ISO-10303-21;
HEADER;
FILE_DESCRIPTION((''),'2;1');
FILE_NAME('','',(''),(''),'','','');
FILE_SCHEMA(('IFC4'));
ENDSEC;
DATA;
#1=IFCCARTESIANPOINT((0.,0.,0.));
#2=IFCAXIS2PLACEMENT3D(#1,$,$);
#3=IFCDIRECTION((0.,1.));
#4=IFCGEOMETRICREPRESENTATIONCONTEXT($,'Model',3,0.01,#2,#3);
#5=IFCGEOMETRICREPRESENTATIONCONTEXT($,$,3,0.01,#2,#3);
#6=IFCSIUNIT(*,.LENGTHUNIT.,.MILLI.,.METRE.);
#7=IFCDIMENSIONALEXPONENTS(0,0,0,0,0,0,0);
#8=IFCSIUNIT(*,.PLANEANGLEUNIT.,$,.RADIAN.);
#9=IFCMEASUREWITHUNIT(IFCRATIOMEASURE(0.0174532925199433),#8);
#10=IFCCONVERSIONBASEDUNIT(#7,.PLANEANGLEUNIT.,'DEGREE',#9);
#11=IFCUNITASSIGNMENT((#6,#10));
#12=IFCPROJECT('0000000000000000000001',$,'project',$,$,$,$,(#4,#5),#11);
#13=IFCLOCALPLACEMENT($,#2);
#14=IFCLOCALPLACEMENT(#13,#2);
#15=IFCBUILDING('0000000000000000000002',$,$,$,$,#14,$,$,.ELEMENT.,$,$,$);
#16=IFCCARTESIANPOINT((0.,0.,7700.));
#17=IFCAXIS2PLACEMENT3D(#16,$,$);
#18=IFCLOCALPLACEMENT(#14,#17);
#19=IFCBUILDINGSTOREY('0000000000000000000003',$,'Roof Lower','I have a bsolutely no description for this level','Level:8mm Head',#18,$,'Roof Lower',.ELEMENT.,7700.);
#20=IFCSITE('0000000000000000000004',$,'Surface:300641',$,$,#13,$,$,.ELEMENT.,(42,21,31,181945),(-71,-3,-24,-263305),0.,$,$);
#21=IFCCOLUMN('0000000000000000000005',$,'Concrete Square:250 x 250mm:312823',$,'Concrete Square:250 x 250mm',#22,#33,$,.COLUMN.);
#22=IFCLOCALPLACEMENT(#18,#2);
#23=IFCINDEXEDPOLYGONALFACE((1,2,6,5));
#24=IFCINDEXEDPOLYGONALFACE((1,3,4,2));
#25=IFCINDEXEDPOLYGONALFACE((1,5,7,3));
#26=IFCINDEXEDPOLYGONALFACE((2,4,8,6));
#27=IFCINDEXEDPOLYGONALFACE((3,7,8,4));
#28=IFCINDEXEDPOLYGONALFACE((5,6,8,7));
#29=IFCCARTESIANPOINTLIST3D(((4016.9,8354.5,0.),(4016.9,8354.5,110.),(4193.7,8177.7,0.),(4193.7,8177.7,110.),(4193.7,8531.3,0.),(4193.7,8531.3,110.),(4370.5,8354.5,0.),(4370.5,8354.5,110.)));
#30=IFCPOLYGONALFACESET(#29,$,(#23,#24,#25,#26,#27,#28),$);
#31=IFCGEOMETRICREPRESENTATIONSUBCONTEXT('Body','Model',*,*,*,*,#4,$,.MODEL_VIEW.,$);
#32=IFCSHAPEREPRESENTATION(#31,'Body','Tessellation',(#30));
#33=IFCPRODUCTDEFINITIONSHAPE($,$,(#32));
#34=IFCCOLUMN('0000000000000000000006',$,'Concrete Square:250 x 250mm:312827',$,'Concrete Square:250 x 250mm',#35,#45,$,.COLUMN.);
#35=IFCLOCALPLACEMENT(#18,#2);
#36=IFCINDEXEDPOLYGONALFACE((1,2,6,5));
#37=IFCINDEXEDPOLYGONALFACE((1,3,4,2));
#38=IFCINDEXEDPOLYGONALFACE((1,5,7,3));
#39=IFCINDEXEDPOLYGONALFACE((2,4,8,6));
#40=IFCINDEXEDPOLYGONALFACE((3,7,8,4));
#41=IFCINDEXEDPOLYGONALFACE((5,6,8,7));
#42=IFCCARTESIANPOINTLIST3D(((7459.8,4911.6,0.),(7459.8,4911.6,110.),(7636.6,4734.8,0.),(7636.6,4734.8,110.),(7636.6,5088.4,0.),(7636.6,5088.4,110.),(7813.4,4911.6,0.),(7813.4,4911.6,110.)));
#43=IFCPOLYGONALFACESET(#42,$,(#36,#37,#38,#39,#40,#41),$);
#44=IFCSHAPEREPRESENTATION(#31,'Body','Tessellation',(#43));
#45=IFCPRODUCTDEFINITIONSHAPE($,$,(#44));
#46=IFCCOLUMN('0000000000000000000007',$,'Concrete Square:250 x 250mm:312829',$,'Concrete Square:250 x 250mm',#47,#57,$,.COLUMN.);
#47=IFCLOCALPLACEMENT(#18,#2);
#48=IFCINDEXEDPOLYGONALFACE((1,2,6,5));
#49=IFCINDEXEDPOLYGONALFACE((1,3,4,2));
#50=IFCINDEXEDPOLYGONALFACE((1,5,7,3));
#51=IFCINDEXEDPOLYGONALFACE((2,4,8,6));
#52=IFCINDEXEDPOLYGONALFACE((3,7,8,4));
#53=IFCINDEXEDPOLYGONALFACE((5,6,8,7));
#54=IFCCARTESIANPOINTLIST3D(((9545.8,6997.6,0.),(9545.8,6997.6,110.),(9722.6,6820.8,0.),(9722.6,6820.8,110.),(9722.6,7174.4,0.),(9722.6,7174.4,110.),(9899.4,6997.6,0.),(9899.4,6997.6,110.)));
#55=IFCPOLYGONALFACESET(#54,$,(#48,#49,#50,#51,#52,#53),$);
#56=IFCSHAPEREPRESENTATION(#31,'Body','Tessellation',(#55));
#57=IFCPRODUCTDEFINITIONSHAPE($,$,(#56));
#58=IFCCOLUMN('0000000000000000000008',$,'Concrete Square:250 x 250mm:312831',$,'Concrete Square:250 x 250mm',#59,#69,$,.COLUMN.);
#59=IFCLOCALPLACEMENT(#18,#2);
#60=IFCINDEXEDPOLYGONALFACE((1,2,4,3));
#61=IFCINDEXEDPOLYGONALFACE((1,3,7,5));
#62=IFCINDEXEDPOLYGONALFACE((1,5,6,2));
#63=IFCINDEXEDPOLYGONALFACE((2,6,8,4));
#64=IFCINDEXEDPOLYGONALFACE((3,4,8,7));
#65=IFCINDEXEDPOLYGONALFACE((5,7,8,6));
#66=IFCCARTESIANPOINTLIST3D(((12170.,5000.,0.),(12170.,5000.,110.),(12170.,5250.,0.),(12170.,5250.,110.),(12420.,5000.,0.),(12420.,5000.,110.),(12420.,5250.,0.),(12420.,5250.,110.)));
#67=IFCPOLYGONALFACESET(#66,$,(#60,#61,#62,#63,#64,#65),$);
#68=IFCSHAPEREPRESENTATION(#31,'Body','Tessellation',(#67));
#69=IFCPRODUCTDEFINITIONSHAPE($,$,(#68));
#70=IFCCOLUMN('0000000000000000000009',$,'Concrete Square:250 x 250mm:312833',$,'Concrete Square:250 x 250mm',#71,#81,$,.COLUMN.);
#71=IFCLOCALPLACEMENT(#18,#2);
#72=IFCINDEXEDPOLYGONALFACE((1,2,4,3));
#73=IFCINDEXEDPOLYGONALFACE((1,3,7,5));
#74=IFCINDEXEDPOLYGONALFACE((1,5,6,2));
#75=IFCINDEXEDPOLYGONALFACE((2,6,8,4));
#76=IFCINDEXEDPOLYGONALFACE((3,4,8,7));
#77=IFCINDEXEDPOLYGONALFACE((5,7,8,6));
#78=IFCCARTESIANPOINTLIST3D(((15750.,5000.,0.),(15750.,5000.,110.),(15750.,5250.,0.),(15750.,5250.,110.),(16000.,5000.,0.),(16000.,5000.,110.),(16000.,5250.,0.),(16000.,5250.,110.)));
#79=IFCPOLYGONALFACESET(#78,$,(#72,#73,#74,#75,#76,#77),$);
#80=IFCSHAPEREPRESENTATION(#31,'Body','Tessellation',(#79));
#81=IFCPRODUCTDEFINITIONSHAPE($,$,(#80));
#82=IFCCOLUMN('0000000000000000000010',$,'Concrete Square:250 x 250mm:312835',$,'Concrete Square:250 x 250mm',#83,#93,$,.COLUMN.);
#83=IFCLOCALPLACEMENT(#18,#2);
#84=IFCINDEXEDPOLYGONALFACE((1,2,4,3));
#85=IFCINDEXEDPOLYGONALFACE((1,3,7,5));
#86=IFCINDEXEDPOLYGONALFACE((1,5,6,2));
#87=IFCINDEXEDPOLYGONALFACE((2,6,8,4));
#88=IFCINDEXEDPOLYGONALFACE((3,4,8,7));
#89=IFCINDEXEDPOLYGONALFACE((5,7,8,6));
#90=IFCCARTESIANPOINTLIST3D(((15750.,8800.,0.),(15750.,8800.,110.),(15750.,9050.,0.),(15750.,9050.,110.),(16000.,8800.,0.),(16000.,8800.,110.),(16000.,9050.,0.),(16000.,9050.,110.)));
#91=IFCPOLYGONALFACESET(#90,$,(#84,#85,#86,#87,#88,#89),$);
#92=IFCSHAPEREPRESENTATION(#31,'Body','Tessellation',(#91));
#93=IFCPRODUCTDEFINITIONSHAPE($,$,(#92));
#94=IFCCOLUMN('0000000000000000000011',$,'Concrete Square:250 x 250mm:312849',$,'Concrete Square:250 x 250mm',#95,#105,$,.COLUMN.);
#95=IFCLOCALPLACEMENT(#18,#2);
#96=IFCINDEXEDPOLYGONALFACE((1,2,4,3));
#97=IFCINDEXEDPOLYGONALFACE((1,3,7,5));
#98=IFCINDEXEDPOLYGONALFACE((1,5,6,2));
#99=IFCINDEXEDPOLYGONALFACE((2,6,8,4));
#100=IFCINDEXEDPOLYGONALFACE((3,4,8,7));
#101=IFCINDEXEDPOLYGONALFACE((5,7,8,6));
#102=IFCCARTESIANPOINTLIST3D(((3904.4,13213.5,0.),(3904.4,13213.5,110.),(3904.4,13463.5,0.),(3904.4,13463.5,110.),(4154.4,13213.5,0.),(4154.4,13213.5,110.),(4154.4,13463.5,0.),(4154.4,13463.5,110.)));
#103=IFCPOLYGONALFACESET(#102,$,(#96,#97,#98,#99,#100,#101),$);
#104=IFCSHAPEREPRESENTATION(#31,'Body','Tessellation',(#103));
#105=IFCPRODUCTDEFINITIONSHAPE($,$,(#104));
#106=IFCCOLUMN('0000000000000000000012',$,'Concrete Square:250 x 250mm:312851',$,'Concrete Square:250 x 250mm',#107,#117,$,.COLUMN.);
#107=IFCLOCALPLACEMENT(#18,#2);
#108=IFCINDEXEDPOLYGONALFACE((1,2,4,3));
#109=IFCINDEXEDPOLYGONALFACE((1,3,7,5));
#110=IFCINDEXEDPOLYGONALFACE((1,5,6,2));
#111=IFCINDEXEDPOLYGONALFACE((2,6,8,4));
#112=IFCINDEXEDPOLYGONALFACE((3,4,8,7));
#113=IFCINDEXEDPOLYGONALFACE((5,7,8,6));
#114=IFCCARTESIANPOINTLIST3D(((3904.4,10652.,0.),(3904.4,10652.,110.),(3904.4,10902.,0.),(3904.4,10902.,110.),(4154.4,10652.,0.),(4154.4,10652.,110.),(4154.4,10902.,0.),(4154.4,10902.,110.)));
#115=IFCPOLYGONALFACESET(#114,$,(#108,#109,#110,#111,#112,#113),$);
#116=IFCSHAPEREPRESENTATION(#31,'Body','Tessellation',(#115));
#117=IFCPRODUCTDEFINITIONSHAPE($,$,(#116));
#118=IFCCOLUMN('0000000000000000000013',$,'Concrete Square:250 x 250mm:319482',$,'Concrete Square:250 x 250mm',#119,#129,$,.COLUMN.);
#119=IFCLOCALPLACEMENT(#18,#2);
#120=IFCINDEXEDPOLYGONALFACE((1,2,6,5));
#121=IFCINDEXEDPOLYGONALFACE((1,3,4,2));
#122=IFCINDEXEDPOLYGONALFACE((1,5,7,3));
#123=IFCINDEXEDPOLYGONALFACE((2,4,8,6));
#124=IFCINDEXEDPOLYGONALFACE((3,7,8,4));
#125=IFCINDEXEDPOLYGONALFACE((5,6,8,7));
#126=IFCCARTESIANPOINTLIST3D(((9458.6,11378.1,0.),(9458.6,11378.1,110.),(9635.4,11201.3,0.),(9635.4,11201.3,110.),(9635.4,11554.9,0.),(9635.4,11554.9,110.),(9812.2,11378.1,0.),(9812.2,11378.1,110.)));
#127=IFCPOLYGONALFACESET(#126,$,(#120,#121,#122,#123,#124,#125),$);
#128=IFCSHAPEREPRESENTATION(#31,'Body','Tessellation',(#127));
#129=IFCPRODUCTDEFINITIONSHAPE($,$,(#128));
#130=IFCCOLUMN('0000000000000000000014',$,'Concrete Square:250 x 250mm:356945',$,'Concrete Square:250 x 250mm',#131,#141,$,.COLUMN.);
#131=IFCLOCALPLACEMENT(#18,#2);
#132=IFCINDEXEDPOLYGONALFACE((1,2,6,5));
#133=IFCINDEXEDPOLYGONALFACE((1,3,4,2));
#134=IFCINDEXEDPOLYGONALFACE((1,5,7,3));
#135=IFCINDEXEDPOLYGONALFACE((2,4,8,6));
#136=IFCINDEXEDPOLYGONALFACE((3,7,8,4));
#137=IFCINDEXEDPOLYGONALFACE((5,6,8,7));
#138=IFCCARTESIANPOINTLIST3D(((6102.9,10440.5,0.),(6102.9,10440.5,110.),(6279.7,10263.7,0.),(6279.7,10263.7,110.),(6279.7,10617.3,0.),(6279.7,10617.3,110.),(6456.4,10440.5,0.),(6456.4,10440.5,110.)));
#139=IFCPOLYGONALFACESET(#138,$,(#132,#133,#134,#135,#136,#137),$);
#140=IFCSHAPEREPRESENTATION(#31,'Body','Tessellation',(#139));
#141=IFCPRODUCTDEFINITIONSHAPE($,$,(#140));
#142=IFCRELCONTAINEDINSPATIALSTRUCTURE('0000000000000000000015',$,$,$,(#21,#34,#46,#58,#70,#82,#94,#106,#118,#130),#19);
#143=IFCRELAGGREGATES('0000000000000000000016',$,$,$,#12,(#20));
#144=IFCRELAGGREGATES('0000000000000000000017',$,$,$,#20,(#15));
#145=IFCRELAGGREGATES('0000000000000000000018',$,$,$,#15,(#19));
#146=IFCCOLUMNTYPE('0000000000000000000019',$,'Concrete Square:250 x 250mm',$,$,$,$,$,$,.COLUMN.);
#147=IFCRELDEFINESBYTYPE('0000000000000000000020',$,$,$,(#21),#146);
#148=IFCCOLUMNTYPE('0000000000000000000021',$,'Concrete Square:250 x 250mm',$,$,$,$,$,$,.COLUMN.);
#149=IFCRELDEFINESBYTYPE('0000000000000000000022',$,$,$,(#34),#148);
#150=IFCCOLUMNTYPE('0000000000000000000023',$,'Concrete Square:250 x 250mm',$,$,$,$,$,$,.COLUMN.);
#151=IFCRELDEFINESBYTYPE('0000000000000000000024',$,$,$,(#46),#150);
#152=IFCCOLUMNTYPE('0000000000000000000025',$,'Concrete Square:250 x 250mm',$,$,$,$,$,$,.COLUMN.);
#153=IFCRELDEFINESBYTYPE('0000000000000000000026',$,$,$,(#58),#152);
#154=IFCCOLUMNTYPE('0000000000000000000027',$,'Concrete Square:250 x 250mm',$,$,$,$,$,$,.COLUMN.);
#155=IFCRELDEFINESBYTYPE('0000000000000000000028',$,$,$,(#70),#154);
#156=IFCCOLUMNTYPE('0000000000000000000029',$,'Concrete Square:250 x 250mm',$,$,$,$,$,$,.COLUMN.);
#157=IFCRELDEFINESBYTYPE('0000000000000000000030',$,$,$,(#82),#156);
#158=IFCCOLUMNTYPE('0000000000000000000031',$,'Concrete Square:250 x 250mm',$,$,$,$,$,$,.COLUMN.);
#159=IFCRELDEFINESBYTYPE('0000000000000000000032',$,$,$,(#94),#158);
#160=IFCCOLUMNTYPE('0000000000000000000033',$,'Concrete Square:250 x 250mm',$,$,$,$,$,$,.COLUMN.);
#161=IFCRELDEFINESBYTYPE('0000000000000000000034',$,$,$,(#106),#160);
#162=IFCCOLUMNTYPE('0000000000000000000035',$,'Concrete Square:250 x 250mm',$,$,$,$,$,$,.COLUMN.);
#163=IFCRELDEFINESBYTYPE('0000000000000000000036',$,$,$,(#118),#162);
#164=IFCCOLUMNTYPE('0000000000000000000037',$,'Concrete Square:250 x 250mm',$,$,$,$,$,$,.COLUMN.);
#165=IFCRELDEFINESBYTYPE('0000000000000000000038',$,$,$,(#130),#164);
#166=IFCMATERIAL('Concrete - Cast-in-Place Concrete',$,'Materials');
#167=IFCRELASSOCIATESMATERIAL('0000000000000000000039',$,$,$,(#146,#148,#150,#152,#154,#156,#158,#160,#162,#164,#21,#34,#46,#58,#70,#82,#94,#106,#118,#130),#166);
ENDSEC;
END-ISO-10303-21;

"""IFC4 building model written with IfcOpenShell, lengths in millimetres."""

from ifc_helpers import new_model, entity, si_unit, converted_unit, direction, frame, frame_2d, origin, origin_2d_with_axis, place, context, subcontext, project, spatial, rectangle, extrude, source, transform, mapped, material, material_profile, profile_set, profile_usage, type_object, type_shapes, element, save


model = new_model("IFC4")

# Units and contexts
model_context = context("Model", 3, precision=0.01, world=origin(), true_north=direction((0.0, 1.0)))
context_of_model = context(None, 3, precision=0.01, world=origin(), true_north=direction((0.0, 1.0)))
body_context = subcontext(model_context, "Body", "Model", "MODEL_VIEW")
ifc_project = project(units=[si_unit("LENGTHUNIT", "METRE", prefix="MILLI"), converted_unit("PLANEANGLEUNIT", "DEGREE", entity("IfcRatioMeasure", 0.0174532925199433), si_unit("PLANEANGLEUNIT", "RADIAN"), dimensions=[0, 0, 0, 0, 0, 0, 0])], contexts=[model_context, context_of_model])

# Site, building, storey
site_placement = place(None, origin())
site = spatial("IfcSite", under=ifc_project, at=site_placement, Name="Surface:300641", CompositionType="ELEMENT", RefLatitude=(42, 21, 31, 181945), RefLongitude=(-71, -3, -24, -263305), RefElevation=0.0)
building_placement = place(site_placement, origin())
building = spatial("IfcBuilding", under=site, at=building_placement, CompositionType="ELEMENT")
storey_placement = place(building_placement, frame((0.0, 0.0, 7700.0)))
storey = spatial("IfcBuildingStorey", under=building, at=storey_placement, Name="Roof Lower", Description="I have a bsolutely no description for this level", ObjectType="Level:8mm Head", LongName="Roof Lower", CompositionType="ELEMENT", Elevation=7700.0)

# Columns
ifc_material_1 = material(Name="Concrete - Cast-in-Place Concrete", Category="Materials")
ifc_material_profile_1 = material_profile(ifc_material_1, rectangle(XDim=250.0, YDim=250.0, at=frame_2d((0.0, 0.0), x_axis=(1.0, 0.0))), Name="250 x 250mm")
ifc_profile_set_1 = profile_set([ifc_material_profile_1], Name="250 x 250mm")
ifc_profile_usage_1 = profile_usage(ifc_profile_set_1)
column_type_1 = type_object("IfcColumnType", Name="Concrete Square:250 x 250mm", PredefinedType="COLUMN", material=ifc_profile_set_1)
shared_shape_1 = source(origin(), body_context, "Body", "SweptSolid", [
    extrude(rectangle(XDim=250.0, YDim=250.0, at=frame_2d((0.0, 0.0), x_axis=(1.0, 0.0))), frame((4193.7, 8354.5, 7700.0), z_axis=(0.0, 0.0, 1.0), x_axis=(-0.707107, 0.707107, 0.0)), (0.0, 0.0, 1.0), 110.0),
])
type_shapes(column_type_1, [shared_shape_1])
column_1_placement = place(storey_placement, frame((0.0, 0.0, -7700.0)))
element("IfcColumn", 1, at=column_1_placement, inside=storey, type_object=column_type_1, material=ifc_profile_usage_1, Name="Concrete Square:250 x 250mm:312823", ObjectType="Concrete Square:250 x 250mm", PredefinedType="COLUMN", context=body_context, shape_type="MappedRepresentation", body=[
    mapped(shared_shape_1, transform((0.0, 0.0, 0.0), scale=1.0)),
])
ifc_profile_usage_2 = profile_usage(ifc_profile_set_1)
column_type_2 = type_object("IfcColumnType", Name="Concrete Square:250 x 250mm", PredefinedType="COLUMN", material=ifc_profile_set_1)
shared_shape_2 = source(origin(), body_context, "Body", "SweptSolid", [
    extrude(rectangle(XDim=250.0, YDim=250.0, at=frame_2d((0.0, 0.0), x_axis=(1.0, 0.0))), frame((7636.6, 4911.6, 7700.0), z_axis=(0.0, 0.0, 1.0), x_axis=(-0.707107, 0.707107, 0.0)), (0.0, 0.0, 1.0), 110.0),
])
type_shapes(column_type_2, [shared_shape_2])
column_2_placement = place(storey_placement, frame((0.0, 0.0, -7700.0)))
element("IfcColumn", 2, at=column_2_placement, inside=storey, type_object=column_type_2, material=ifc_profile_usage_2, Name="Concrete Square:250 x 250mm:312827", ObjectType="Concrete Square:250 x 250mm", PredefinedType="COLUMN", context=body_context, shape_type="MappedRepresentation", body=[
    mapped(shared_shape_2, transform((0.0, 0.0, 0.0), scale=1.0)),
])
ifc_profile_usage_3 = profile_usage(ifc_profile_set_1)
column_type_3 = type_object("IfcColumnType", Name="Concrete Square:250 x 250mm", PredefinedType="COLUMN", material=ifc_profile_set_1)
shared_shape_3 = source(origin(), body_context, "Body", "SweptSolid", [
    extrude(rectangle(XDim=250.0, YDim=250.0, at=frame_2d((0.0, 0.0), x_axis=(1.0, 0.0))), frame((9722.6, 6997.6, 7700.0), z_axis=(0.0, 0.0, 1.0), x_axis=(-0.707107, 0.707107, 0.0)), (0.0, 0.0, 1.0), 110.0),
])
type_shapes(column_type_3, [shared_shape_3])
column_3_placement = place(storey_placement, frame((0.0, 0.0, -7700.0)))
element("IfcColumn", 3, at=column_3_placement, inside=storey, type_object=column_type_3, material=ifc_profile_usage_3, Name="Concrete Square:250 x 250mm:312829", ObjectType="Concrete Square:250 x 250mm", PredefinedType="COLUMN", context=body_context, shape_type="MappedRepresentation", body=[
    mapped(shared_shape_3, transform((0.0, 0.0, 0.0), scale=1.0)),
])
ifc_profile_usage_4 = profile_usage(ifc_profile_set_1)
column_type_4 = type_object("IfcColumnType", Name="Concrete Square:250 x 250mm", PredefinedType="COLUMN", material=ifc_profile_set_1)
shared_shape_4 = source(origin(), body_context, "Body", "SweptSolid", [
    extrude(rectangle(XDim=250.0, YDim=250.0, at=origin_2d_with_axis()), frame((12295.0, 5125.0, 7700.0), z_axis=(0.0, 0.0, 1.0), x_axis=(0.0, -1.0, 0.0)), (0.0, 0.0, 1.0), 110.0),
])
type_shapes(column_type_4, [shared_shape_4])
column_4_placement = place(storey_placement, frame((0.0, 0.0, -7700.0)))
element("IfcColumn", 4, at=column_4_placement, inside=storey, type_object=column_type_4, material=ifc_profile_usage_4, Name="Concrete Square:250 x 250mm:312831", ObjectType="Concrete Square:250 x 250mm", PredefinedType="COLUMN", context=body_context, shape_type="MappedRepresentation", body=[
    mapped(shared_shape_4, transform((0.0, 0.0, 0.0), scale=1.0)),
])
ifc_profile_usage_5 = profile_usage(ifc_profile_set_1)
column_type_5 = type_object("IfcColumnType", Name="Concrete Square:250 x 250mm", PredefinedType="COLUMN", material=ifc_profile_set_1)
shared_shape_5 = source(origin(), body_context, "Body", "SweptSolid", [
    extrude(rectangle(XDim=250.0, YDim=250.0, at=origin_2d_with_axis()), frame((15875.0, 5125.0, 7700.0), z_axis=(0.0, 0.0, 1.0), x_axis=(0.0, -1.0, 0.0)), (0.0, 0.0, 1.0), 110.0),
])
type_shapes(column_type_5, [shared_shape_5])
column_5_placement = place(storey_placement, frame((0.0, 0.0, -7700.0)))
element("IfcColumn", 5, at=column_5_placement, inside=storey, type_object=column_type_5, material=ifc_profile_usage_5, Name="Concrete Square:250 x 250mm:312833", ObjectType="Concrete Square:250 x 250mm", PredefinedType="COLUMN", context=body_context, shape_type="MappedRepresentation", body=[
    mapped(shared_shape_5, transform((0.0, 0.0, 0.0), scale=1.0)),
])
ifc_profile_usage_6 = profile_usage(ifc_profile_set_1)
column_type_6 = type_object("IfcColumnType", Name="Concrete Square:250 x 250mm", PredefinedType="COLUMN", material=ifc_profile_set_1)
shared_shape_6 = source(origin(), body_context, "Body", "SweptSolid", [
    extrude(rectangle(XDim=250.0, YDim=250.0, at=frame_2d((0.0, 0.0), x_axis=(1.0, 0.0))), frame((15875.0, 8925.0, 7700.0), z_axis=(0.0, 0.0, 1.0), x_axis=(0.0, -1.0, 0.0)), (0.0, 0.0, 1.0), 110.0),
])
type_shapes(column_type_6, [shared_shape_6])
column_6_placement = place(storey_placement, frame((0.0, 0.0, -7700.0)))
element("IfcColumn", 6, at=column_6_placement, inside=storey, type_object=column_type_6, material=ifc_profile_usage_6, Name="Concrete Square:250 x 250mm:312835", ObjectType="Concrete Square:250 x 250mm", PredefinedType="COLUMN", context=body_context, shape_type="MappedRepresentation", body=[
    mapped(shared_shape_6, transform((0.0, 0.0, 0.0), scale=1.0)),
])
ifc_profile_usage_7 = profile_usage(ifc_profile_set_1)
column_type_7 = type_object("IfcColumnType", Name="Concrete Square:250 x 250mm", PredefinedType="COLUMN", material=ifc_profile_set_1)
shared_shape_7 = source(origin(), body_context, "Body", "SweptSolid", [
    extrude(rectangle(XDim=250.0, YDim=250.0, at=frame_2d((0.0, 0.0), x_axis=(1.0, 0.0))), frame((4029.4, 13338.5, 7700.0), z_axis=(0.0, 0.0, 1.0), x_axis=(0.0, -1.0, 0.0)), (0.0, 0.0, 1.0), 110.0),
])
type_shapes(column_type_7, [shared_shape_7])
column_7_placement = place(storey_placement, frame((0.0, 0.0, -7700.0)))
element("IfcColumn", 7, at=column_7_placement, inside=storey, type_object=column_type_7, material=ifc_profile_usage_7, Name="Concrete Square:250 x 250mm:312849", ObjectType="Concrete Square:250 x 250mm", PredefinedType="COLUMN", context=body_context, shape_type="MappedRepresentation", body=[
    mapped(shared_shape_7, transform((0.0, 0.0, 0.0), scale=1.0)),
])
ifc_profile_usage_8 = profile_usage(ifc_profile_set_1)
column_type_8 = type_object("IfcColumnType", Name="Concrete Square:250 x 250mm", PredefinedType="COLUMN", material=ifc_profile_set_1)
shared_shape_8 = source(origin(), body_context, "Body", "SweptSolid", [
    extrude(rectangle(XDim=250.0, YDim=250.0, at=frame_2d((0.0, 0.0), x_axis=(1.0, 0.0))), frame((4029.4, 10777.0, 7700.0), z_axis=(0.0, 0.0, 1.0), x_axis=(0.0, -1.0, 0.0)), (0.0, 0.0, 1.0), 110.0),
])
type_shapes(column_type_8, [shared_shape_8])
column_8_placement = place(storey_placement, frame((0.0, 0.0, -7700.0)))
element("IfcColumn", 8, at=column_8_placement, inside=storey, type_object=column_type_8, material=ifc_profile_usage_8, Name="Concrete Square:250 x 250mm:312851", ObjectType="Concrete Square:250 x 250mm", PredefinedType="COLUMN", context=body_context, shape_type="MappedRepresentation", body=[
    mapped(shared_shape_8, transform((0.0, 0.0, 0.0), scale=1.0)),
])
ifc_profile_usage_9 = profile_usage(ifc_profile_set_1)
column_type_9 = type_object("IfcColumnType", Name="Concrete Square:250 x 250mm", PredefinedType="COLUMN", material=ifc_profile_set_1)
shared_shape_9 = source(origin(), body_context, "Body", "SweptSolid", [
    extrude(rectangle(XDim=250.0, YDim=250.0, at=frame_2d((0.0, 0.0), x_axis=(1.0, 0.0))), frame((9635.4, 11378.1, 7700.0), z_axis=(0.0, 0.0, 1.0), x_axis=(-0.707107, 0.707107, 0.0)), (0.0, 0.0, 1.0), 110.0),
])
type_shapes(column_type_9, [shared_shape_9])
column_9_placement = place(storey_placement, frame((0.0, 0.0, -7700.0)))
element("IfcColumn", 9, at=column_9_placement, inside=storey, type_object=column_type_9, material=ifc_profile_usage_9, Name="Concrete Square:250 x 250mm:319482", ObjectType="Concrete Square:250 x 250mm", PredefinedType="COLUMN", context=body_context, shape_type="MappedRepresentation", body=[
    mapped(shared_shape_9, transform((0.0, 0.0, 0.0), scale=1.0)),
])
ifc_profile_usage_10 = profile_usage(ifc_profile_set_1)
column_type_10 = type_object("IfcColumnType", Name="Concrete Square:250 x 250mm", PredefinedType="COLUMN", material=ifc_profile_set_1)
shared_shape_10 = source(origin(), body_context, "Body", "SweptSolid", [
    extrude(rectangle(XDim=250.0, YDim=250.0, at=origin_2d_with_axis()), frame((6279.7, 10440.5, 7700.0), z_axis=(0.0, 0.0, 1.0), x_axis=(-0.707107, 0.707107, 0.0)), (0.0, 0.0, 1.0), 110.0),
])
type_shapes(column_type_10, [shared_shape_10])
column_10_placement = place(storey_placement, frame((0.0, 0.0, -7700.0)))
element("IfcColumn", 10, at=column_10_placement, inside=storey, type_object=column_type_10, material=ifc_profile_usage_10, Name="Concrete Square:250 x 250mm:356945", ObjectType="Concrete Square:250 x 250mm", PredefinedType="COLUMN", context=body_context, shape_type="MappedRepresentation", body=[
    mapped(shared_shape_10, transform((0.0, 0.0, 0.0), scale=1.0)),
])

save(model, "model.ifc")
